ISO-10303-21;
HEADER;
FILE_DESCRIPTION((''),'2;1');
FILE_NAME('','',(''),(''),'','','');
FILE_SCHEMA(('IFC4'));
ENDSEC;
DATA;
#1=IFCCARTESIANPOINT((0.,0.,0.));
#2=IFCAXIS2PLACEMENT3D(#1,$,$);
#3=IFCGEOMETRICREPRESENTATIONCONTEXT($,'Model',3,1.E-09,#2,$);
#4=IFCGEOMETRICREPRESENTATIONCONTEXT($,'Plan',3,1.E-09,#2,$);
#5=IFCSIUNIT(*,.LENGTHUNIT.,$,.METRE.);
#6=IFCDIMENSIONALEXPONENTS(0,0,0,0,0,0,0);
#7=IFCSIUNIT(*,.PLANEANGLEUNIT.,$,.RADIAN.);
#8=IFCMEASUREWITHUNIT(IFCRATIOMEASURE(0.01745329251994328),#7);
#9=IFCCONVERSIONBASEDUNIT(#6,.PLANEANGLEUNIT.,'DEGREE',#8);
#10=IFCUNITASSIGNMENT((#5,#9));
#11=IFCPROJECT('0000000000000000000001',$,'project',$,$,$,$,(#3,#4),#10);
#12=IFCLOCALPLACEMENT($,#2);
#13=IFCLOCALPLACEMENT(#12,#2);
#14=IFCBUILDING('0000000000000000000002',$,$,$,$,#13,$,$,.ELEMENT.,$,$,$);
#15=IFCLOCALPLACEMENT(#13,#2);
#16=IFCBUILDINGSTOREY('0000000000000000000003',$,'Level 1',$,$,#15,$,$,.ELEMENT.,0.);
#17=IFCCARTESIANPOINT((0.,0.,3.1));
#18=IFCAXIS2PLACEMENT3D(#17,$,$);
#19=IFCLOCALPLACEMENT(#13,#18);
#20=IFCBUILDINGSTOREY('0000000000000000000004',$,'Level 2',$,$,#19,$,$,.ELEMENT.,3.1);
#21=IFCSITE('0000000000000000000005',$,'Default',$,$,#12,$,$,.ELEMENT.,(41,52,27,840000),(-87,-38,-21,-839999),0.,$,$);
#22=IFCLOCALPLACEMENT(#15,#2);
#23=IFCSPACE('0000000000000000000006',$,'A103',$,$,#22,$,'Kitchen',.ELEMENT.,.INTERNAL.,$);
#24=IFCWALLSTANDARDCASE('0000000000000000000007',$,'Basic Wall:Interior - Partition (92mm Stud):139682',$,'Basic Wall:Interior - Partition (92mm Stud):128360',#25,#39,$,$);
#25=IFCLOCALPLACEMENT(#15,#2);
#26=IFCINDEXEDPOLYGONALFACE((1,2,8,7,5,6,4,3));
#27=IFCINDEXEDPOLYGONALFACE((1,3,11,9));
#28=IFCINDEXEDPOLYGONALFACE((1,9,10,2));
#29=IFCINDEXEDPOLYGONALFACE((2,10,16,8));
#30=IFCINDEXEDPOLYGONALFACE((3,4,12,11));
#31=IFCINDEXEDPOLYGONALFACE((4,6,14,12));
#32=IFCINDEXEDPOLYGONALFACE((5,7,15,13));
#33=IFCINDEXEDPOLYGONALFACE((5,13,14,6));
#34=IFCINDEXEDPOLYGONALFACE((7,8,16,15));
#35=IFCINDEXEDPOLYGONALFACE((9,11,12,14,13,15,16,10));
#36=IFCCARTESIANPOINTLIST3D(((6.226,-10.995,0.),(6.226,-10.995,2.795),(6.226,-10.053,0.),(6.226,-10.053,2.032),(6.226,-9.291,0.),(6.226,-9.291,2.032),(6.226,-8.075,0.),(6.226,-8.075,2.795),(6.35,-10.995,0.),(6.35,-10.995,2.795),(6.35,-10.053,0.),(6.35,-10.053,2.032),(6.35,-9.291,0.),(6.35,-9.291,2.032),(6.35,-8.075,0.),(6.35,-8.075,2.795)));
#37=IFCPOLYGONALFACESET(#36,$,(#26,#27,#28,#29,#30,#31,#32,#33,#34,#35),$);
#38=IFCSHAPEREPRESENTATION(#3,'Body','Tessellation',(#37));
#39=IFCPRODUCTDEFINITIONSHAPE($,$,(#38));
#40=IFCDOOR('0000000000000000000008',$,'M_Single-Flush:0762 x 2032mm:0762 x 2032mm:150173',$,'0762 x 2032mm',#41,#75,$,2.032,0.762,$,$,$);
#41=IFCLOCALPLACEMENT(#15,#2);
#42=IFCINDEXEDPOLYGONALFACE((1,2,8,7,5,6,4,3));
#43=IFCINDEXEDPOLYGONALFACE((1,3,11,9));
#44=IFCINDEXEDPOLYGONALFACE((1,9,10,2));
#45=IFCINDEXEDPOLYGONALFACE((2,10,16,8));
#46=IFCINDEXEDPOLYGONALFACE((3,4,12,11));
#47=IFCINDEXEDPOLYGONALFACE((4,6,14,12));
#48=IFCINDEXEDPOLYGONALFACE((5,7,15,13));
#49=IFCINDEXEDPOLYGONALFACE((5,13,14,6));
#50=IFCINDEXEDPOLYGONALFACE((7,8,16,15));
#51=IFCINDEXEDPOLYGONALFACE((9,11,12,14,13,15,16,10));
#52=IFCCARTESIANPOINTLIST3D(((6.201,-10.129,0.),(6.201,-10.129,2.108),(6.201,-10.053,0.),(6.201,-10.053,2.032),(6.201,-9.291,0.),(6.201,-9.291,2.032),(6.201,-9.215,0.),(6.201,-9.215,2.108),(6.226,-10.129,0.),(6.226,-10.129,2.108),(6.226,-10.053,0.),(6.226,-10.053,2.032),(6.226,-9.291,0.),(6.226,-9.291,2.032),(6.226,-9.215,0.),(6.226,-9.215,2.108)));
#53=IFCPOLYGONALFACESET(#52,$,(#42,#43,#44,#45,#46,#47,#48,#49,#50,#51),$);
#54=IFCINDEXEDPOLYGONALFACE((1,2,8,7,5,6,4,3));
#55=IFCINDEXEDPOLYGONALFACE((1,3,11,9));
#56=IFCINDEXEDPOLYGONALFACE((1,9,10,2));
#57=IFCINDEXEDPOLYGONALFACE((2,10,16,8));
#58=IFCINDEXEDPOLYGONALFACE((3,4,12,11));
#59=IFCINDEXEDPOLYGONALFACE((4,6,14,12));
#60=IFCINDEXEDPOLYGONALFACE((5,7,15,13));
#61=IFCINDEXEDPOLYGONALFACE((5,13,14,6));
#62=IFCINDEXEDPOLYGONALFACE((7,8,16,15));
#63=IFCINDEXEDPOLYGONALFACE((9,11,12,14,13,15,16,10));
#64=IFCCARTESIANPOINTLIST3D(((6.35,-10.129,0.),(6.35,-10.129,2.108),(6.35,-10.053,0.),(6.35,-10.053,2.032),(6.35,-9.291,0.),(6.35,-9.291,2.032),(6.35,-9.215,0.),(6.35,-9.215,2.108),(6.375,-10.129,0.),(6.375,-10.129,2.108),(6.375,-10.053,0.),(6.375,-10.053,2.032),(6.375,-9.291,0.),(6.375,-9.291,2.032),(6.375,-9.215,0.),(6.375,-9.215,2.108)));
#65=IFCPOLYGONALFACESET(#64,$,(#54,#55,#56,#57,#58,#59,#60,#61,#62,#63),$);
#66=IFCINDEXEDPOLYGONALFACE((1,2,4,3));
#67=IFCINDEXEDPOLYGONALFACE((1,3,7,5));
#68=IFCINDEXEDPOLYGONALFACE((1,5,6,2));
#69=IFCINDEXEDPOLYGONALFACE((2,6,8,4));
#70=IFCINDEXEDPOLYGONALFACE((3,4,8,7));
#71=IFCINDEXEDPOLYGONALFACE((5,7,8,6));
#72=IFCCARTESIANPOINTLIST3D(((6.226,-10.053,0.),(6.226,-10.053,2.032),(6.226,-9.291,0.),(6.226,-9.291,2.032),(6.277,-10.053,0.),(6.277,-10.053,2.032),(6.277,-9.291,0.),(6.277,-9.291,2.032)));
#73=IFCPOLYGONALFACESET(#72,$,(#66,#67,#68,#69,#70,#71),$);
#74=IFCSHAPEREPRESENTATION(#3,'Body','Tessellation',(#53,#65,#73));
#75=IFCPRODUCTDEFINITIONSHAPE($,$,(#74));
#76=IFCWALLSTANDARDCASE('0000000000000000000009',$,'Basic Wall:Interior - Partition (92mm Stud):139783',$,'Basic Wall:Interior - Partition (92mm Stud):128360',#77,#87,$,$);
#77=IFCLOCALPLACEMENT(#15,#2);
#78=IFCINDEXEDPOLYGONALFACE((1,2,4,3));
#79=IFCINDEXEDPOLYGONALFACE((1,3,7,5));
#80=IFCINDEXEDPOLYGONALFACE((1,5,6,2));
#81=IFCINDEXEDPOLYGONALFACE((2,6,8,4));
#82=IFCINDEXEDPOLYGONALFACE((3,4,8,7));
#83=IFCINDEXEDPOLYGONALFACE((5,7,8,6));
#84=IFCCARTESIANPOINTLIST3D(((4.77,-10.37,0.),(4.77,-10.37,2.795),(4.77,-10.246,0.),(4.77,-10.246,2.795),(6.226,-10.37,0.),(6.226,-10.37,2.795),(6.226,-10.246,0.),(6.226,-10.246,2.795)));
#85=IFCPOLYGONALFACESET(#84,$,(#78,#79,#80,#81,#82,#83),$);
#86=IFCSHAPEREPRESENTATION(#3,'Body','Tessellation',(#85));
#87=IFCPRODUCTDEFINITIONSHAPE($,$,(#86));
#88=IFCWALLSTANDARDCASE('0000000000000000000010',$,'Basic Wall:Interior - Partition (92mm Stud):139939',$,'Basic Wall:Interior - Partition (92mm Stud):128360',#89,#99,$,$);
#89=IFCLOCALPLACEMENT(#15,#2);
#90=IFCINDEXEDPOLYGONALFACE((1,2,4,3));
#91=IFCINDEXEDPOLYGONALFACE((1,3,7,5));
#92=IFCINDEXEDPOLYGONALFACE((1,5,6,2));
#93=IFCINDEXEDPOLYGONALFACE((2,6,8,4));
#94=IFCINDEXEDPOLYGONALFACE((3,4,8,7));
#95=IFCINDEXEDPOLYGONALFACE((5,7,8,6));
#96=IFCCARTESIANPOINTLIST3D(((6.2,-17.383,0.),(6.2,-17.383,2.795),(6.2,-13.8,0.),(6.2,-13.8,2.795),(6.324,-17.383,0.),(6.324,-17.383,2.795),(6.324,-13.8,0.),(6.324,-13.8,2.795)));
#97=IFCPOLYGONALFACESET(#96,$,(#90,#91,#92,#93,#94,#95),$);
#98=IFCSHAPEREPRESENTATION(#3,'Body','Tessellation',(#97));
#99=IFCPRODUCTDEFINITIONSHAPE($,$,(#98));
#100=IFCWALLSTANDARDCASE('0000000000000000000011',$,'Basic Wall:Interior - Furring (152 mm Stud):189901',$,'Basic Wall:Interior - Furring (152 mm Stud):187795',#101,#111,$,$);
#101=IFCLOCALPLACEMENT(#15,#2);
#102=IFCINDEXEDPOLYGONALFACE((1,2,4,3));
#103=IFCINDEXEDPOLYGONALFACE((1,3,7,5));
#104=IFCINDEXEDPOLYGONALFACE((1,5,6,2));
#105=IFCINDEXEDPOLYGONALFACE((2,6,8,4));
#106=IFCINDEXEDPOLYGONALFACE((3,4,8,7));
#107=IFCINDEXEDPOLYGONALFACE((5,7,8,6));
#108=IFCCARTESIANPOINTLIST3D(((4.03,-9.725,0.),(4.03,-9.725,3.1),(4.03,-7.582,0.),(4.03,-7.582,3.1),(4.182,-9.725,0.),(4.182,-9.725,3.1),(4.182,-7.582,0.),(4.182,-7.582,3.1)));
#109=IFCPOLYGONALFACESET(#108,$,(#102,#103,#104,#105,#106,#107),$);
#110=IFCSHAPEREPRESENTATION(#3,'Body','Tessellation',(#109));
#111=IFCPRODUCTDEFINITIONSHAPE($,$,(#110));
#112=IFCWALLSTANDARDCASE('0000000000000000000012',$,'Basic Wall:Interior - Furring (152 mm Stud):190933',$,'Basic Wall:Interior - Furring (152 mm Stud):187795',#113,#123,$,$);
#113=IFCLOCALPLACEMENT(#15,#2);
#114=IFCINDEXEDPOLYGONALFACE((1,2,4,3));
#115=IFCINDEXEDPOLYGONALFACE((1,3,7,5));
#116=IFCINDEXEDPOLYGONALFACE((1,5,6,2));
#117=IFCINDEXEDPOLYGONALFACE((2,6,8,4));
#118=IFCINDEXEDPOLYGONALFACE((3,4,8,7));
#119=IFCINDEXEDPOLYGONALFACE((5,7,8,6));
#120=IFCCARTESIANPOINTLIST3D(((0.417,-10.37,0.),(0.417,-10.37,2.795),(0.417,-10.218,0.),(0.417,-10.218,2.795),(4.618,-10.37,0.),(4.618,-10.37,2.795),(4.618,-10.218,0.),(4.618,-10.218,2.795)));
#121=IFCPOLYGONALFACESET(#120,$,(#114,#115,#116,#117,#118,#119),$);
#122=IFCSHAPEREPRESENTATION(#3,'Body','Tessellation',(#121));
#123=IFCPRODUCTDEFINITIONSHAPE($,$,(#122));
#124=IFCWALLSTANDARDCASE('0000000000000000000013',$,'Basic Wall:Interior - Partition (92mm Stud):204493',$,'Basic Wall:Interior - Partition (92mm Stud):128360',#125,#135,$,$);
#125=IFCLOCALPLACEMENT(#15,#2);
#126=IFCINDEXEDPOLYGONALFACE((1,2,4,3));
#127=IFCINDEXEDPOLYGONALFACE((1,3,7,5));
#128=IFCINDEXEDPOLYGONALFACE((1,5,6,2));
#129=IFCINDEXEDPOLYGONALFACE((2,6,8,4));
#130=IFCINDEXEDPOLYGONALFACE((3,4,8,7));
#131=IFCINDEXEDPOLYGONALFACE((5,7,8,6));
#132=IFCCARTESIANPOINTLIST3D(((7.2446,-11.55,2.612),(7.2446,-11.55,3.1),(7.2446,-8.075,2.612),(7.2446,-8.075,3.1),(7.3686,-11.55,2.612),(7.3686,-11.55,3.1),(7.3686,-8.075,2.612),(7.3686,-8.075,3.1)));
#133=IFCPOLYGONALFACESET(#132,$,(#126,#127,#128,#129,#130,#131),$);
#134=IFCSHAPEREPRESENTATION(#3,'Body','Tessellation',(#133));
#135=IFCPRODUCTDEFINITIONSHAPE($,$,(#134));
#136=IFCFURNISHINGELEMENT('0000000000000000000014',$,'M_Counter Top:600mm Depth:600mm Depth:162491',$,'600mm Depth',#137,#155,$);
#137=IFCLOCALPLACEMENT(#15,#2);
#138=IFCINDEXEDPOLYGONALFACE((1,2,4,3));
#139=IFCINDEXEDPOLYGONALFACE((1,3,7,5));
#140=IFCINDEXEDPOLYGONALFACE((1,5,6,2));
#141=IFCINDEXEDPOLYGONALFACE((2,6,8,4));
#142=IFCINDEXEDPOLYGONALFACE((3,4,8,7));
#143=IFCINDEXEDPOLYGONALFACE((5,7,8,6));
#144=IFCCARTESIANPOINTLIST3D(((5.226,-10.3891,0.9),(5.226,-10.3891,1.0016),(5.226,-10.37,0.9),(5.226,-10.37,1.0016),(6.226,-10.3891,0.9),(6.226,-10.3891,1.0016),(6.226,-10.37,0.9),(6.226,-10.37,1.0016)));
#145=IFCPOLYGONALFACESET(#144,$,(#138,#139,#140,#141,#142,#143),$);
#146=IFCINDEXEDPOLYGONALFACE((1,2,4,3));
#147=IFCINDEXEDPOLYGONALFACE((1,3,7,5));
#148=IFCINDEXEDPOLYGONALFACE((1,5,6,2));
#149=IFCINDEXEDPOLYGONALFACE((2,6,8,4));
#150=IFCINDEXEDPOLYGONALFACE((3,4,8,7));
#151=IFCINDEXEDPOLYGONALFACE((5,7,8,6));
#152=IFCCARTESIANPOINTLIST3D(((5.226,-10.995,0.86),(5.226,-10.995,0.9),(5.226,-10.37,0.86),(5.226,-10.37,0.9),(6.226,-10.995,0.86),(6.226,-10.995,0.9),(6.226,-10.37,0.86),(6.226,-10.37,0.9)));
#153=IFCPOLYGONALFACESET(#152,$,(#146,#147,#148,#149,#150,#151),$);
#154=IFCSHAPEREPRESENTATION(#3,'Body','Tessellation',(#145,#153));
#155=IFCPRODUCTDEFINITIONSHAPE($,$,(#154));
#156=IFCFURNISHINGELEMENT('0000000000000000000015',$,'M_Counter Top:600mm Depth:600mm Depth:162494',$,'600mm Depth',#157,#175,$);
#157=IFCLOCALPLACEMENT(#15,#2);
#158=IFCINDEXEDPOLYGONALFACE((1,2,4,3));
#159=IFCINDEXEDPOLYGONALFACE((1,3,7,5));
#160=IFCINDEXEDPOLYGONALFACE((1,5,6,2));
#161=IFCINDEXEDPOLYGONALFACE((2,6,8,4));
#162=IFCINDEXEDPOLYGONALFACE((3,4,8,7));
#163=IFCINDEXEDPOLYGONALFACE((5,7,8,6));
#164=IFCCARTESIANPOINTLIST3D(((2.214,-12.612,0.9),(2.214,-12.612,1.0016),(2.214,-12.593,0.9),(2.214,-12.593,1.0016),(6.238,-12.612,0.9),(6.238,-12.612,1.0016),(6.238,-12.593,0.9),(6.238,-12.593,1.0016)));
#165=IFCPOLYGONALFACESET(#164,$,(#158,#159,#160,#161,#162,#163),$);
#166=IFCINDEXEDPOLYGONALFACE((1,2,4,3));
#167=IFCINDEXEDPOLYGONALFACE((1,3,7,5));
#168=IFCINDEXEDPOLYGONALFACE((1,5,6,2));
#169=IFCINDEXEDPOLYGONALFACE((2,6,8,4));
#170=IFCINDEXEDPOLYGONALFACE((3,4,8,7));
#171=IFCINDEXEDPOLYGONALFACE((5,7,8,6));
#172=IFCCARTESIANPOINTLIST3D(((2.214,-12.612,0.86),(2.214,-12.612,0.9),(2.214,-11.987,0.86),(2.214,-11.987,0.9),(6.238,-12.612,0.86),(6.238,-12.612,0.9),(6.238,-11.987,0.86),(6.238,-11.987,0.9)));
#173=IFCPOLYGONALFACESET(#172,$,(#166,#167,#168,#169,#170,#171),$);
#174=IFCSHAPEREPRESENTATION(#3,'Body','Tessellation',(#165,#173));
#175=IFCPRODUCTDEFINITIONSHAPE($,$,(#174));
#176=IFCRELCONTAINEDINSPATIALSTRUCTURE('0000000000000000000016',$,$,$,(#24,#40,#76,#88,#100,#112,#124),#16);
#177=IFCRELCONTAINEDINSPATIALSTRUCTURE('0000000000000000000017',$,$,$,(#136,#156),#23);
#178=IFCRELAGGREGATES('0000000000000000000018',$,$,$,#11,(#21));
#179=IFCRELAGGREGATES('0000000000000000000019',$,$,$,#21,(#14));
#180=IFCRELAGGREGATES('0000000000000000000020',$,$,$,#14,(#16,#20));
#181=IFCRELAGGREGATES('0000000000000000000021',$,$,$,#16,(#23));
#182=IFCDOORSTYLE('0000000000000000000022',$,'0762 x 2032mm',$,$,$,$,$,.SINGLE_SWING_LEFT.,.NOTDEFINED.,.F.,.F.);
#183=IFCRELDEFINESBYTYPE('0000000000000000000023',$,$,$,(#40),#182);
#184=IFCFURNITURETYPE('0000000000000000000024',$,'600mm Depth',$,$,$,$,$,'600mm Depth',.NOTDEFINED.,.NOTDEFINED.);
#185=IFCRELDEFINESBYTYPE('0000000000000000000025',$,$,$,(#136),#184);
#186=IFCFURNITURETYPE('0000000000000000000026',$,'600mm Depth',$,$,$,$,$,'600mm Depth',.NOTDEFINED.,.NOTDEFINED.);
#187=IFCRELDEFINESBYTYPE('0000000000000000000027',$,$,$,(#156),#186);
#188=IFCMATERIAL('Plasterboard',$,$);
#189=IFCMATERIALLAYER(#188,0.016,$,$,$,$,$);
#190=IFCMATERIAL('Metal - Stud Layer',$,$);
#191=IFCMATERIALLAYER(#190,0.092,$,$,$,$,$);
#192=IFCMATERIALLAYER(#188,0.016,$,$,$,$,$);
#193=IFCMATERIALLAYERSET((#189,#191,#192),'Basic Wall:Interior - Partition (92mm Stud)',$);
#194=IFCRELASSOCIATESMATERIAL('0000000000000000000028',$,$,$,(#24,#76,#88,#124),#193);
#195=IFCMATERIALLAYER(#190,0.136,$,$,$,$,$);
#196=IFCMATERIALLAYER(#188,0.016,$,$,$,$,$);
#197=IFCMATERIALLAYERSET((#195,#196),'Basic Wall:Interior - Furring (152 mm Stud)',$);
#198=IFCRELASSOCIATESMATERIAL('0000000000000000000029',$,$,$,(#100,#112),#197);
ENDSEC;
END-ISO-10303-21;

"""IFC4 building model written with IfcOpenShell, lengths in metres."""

from ifc_helpers import new_model, entity, si_unit, converted_unit, frame, frame_2d, origin, origin_2d_with_axis, place, context, project, spatial, polyline, rectangle, outline, extrude, source, transform, mapped, material, layer, layer_set, layer_usage, type_object, type_shapes, element, fill, save


model = new_model("IFC4")

# Units and contexts
model_context = context("Model", 3, precision=1e-09, world=origin())
plan_context = context("Plan", 3, precision=1e-09, world=origin())
ifc_project = project(units=[si_unit("LENGTHUNIT", "METRE"), converted_unit("PLANEANGLEUNIT", "DEGREE", entity("IfcRatioMeasure", 0.01745329251994328), si_unit("PLANEANGLEUNIT", "RADIAN"), dimensions=[0, 0, 0, 0, 0, 0, 0])], contexts=[model_context, plan_context])

# Site, building, storey
site_placement = place(None, origin())
site = spatial("IfcSite", under=ifc_project, at=site_placement, Name="Default", CompositionType="ELEMENT", RefLatitude=(41, 52, 27, 840000), RefLongitude=(-87, -38, -21, -839999), RefElevation=0.0)
building_placement = place(site_placement, origin())
building = spatial("IfcBuilding", under=site, at=building_placement, CompositionType="ELEMENT")
storey_1_placement = place(building_placement, origin())
storey_1 = spatial("IfcBuildingStorey", under=building, at=storey_1_placement, Name="Level 1", CompositionType="ELEMENT", Elevation=0.0)

# Shared definitions
ifc_material_1 = material(Name="Metal - Stud Layer")
ifc_material_2 = material(Name="Plasterboard")

# Wall, opening, door
ifc_layer_1 = layer(ifc_material_2, 0.016)
ifc_layer_2 = layer(ifc_material_1, 0.092)
ifc_layer_3 = layer(ifc_material_2, 0.016)
ifc_layer_set_1 = layer_set([ifc_layer_1, ifc_layer_2, ifc_layer_3], Name="Basic Wall:Interior - Partition (92mm Stud)")
ifc_layer_usage_1 = layer_usage(ifc_layer_set_1, "AXIS2", "NEGATIVE", 0.062)
wall_1_placement = place(storey_1_placement, frame((6.288, -10.995, 0.0), z_axis=(0.0, 0.0, 1.0), x_axis=(0.0, 1.0, 0.0)))
wall_1 = element("IfcWallStandardCase", 1, at=wall_1_placement, inside=storey_1, material=ifc_layer_usage_1, Name="Basic Wall:Interior - Partition (92mm Stud):139682", ObjectType="Basic Wall:Interior - Partition (92mm Stud):128360", context=model_context, shape_type="SweptSolid", body=[
    extrude(rectangle(XDim=2.92, YDim=0.124, at=frame_2d((1.46, 0.0), x_axis=(-1.0, 0.0))), origin(), (0.0, 0.0, 1.0), 2.795),
])
opening_1_placement = place(wall_1_placement, frame((0.942, -0.062, 0.0)))
opening_1 = element("IfcOpeningElement", 2, at=opening_1_placement, cuts=wall_1, ObjectType="Opening", context=model_context, shape_type="SweptSolid", body=[
    extrude(rectangle(XDim=0.762, YDim=2.032, at=frame_2d((1.016, 0.381), x_axis=(0.0, -1.0))), frame((0.0, 0.0, 0.0), z_axis=(0.0, 1.0, 0.0), x_axis=(0.0, 0.0, 1.0)), (0.0, 0.0, 1.0), 0.124),
])
door_style_1 = type_object("IfcDoorStyle", Name="0762 x 2032mm", ConstructionType="NOTDEFINED", OperationType="SINGLE_SWING_LEFT", ParameterTakesPrecedence=False, Sizeable=False)
shared_shape_1 = source(origin(), model_context, "Body", "SweptSolid", [
    extrude(outline(polyline([(-0.457, -1.073), (0.457, -1.073), (0.457, 1.035), (0.381, 1.035), (0.381, -0.997), (-0.381, -0.997), (-0.381, 1.035), (-0.457, 1.035), (-0.457, -1.073)])), frame((0.381, 0.149, 1.035), z_axis=(0.0, -1.0, 0.0), x_axis=(-1.0, 0.0, 0.0)), (0.0, 0.0, 1.0), 0.025),
    extrude(outline(polyline([(-1.073, -0.457), (1.035, -0.457), (1.035, -0.381), (-0.997, -0.381), (-0.997, 0.381), (1.035, 0.381), (1.035, 0.457), (-1.073, 0.457), (-1.073, -0.457)])), frame((0.381, 0.0, 1.035), z_axis=(0.0, -1.0, 0.0), x_axis=(0.0, 0.0, -1.0)), (0.0, 0.0, 1.0), 0.025),
    extrude(rectangle(XDim=0.762, YDim=0.051, at=origin_2d_with_axis()), frame((0.381, 0.0985, 0.0)), (0.0, 0.0, 1.0), 2.032),
])
type_shapes(door_style_1, [shared_shape_1])
door_1_placement = place(opening_1_placement, origin())
door_1 = element("IfcDoor", 3, at=door_1_placement, inside=storey_1, type_object=door_style_1, Name="M_Single-Flush:0762 x 2032mm:0762 x 2032mm:150173", ObjectType="0762 x 2032mm", OverallHeight=2.032, OverallWidth=0.762, context=model_context, shape_type="MappedRepresentation", body=[
    mapped(shared_shape_1, transform((0.0, 0.0, 0.0), scale=1.0)),
])
fill(opening_1, door_1)

# Walls
ifc_layer_usage_2 = layer_usage(ifc_layer_set_1, "AXIS2", "NEGATIVE", 0.062)
wall_2_placement = place(storey_1_placement, frame((4.77, -10.308, 0.0)))
element("IfcWallStandardCase", 4, at=wall_2_placement, inside=storey_1, material=ifc_layer_usage_2, Name="Basic Wall:Interior - Partition (92mm Stud):139783", ObjectType="Basic Wall:Interior - Partition (92mm Stud):128360", context=model_context, shape_type="SweptSolid", body=[
    extrude(rectangle(XDim=1.456, YDim=0.124, at=frame_2d((0.728, 0.0), x_axis=(-1.0, 0.0))), origin(), (0.0, 0.0, 1.0), 2.795),
])
ifc_layer_usage_3 = layer_usage(ifc_layer_set_1, "AXIS2", "NEGATIVE", 0.062)
wall_3_placement = place(storey_1_placement, frame((6.262, -13.8, 0.0), z_axis=(0.0, 0.0, 1.0), x_axis=(0.0, -1.0, 0.0)))
element("IfcWallStandardCase", 5, at=wall_3_placement, inside=storey_1, material=ifc_layer_usage_3, Name="Basic Wall:Interior - Partition (92mm Stud):139939", ObjectType="Basic Wall:Interior - Partition (92mm Stud):128360", context=model_context, shape_type="SweptSolid", body=[
    extrude(rectangle(XDim=3.583, YDim=0.124, at=frame_2d((1.7915, 0.0), x_axis=(-1.0, 0.0))), origin(), (0.0, 0.0, 1.0), 2.795),
])

# Shared definitions
storey_2_placement = place(building_placement, frame((0.0, 0.0, 3.1)))
storey_2 = spatial("IfcBuildingStorey", under=building, at=storey_2_placement, Name="Level 2", CompositionType="ELEMENT", Elevation=3.1)

# Walls
ifc_layer_4 = layer(ifc_material_1, 0.136)
ifc_layer_5 = layer(ifc_material_2, 0.016)
ifc_layer_set_2 = layer_set([ifc_layer_4, ifc_layer_5], Name="Basic Wall:Interior - Furring (152 mm Stud)")
ifc_layer_usage_4 = layer_usage(ifc_layer_set_2, "AXIS2", "POSITIVE", -0.076)
wall_4_placement = place(storey_1_placement, frame((4.106, -9.725, 0.0), z_axis=(0.0, 0.0, 1.0), x_axis=(0.0, 1.0, 0.0)))
element("IfcWallStandardCase", 6, at=wall_4_placement, inside=storey_1, material=ifc_layer_usage_4, Name="Basic Wall:Interior - Furring (152 mm Stud):189901", ObjectType="Basic Wall:Interior - Furring (152 mm Stud):187795", context=model_context, shape_type="SweptSolid", body=[
    extrude(rectangle(XDim=2.143, YDim=0.152, at=frame_2d((1.0715, 0.0), x_axis=(-1.0, 0.0))), origin(), (0.0, 0.0, 1.0), 3.1),
])
ifc_layer_usage_5 = layer_usage(ifc_layer_set_2, "AXIS2", "NEGATIVE", 0.076)
wall_5_placement = place(storey_1_placement, frame((0.417, -10.294, 0.0)))
element("IfcWallStandardCase", 7, at=wall_5_placement, inside=storey_1, material=ifc_layer_usage_5, Name="Basic Wall:Interior - Furring (152 mm Stud):190933", ObjectType="Basic Wall:Interior - Furring (152 mm Stud):187795", context=model_context, shape_type="SweptSolid", body=[
    extrude(rectangle(XDim=4.201, YDim=0.152, at=frame_2d((2.1005, 0.0), x_axis=(-1.0, 0.0))), origin(), (0.0, 0.0, 1.0), 2.795),
])
ifc_layer_usage_6 = layer_usage(ifc_layer_set_1, "AXIS2", "NEGATIVE", 0.062)
wall_6_placement = place(storey_1_placement, frame((7.3066, -11.55, 2.612), z_axis=(0.0, 0.0, 1.0), x_axis=(0.0, 1.0, 0.0)))
element("IfcWallStandardCase", 8, at=wall_6_placement, inside=storey_1, material=ifc_layer_usage_6, Name="Basic Wall:Interior - Partition (92mm Stud):204493", ObjectType="Basic Wall:Interior - Partition (92mm Stud):128360", context=model_context, shape_type="SweptSolid", body=[
    extrude(rectangle(XDim=3.475, YDim=0.124, at=frame_2d((1.7375, 0.0), x_axis=(-1.0, 0.0))), origin(), (0.0, 0.0, 1.0), 0.488),
])

# Shared definitions
space_1_placement = place(storey_1_placement, origin())
space_1 = spatial("IfcSpace", under=storey_1, at=space_1_placement, Name="A103", LongName="Kitchen", CompositionType="ELEMENT", PredefinedType="INTERNAL")

# Furnishing elements
furniture_type_1 = type_object("IfcFurnitureType", Name="600mm Depth", ElementType="600mm Depth", AssemblyPlace="NOTDEFINED")
shared_shape_2 = source(origin(), model_context, "Body", "SweptSolid", [
    extrude(rectangle(XDim=0.0191, YDim=1.0, at=origin_2d_with_axis()), frame((-0.7005, -0.0095, 0.9), z_axis=(0.0, 0.0, 1.0), x_axis=(0.0, -1.0, 0.0)), (0.0, 0.0, 1.0), 0.1016),
    extrude(rectangle(XDim=1.0, YDim=0.625, at=origin_2d_with_axis()), frame((-0.7005, -0.3125, 0.86), z_axis=(0.0, 0.0, 1.0), x_axis=(-1.0, 0.0, 0.0)), (0.0, 0.0, 1.0), 0.04),
])
type_shapes(furniture_type_1, [shared_shape_2])
furnishing_1_placement = place(space_1_placement, frame((6.4265, -10.37, 0.0)))
element("IfcFurnishingElement", 9, at=furnishing_1_placement, inside=space_1, type_object=furniture_type_1, Name="M_Counter Top:600mm Depth:600mm Depth:162491", ObjectType="600mm Depth", context=model_context, shape_type="MappedRepresentation", body=[
    mapped(shared_shape_2, transform((0.0, 0.0, 0.0), scale=1.0)),
])
furniture_type_2 = type_object("IfcFurnitureType", Name="600mm Depth", ElementType="600mm Depth", AssemblyPlace="NOTDEFINED")
shared_shape_3 = source(origin(), model_context, "Body", "SweptSolid", [
    extrude(rectangle(XDim=0.0191, YDim=4.024, at=origin_2d_with_axis()), frame((0.8115, -0.0095, 0.9), z_axis=(0.0, 0.0, 1.0), x_axis=(0.0, -1.0, 0.0)), (0.0, 0.0, 1.0), 0.1016),
    extrude(rectangle(XDim=4.024, YDim=0.625, at=origin_2d_with_axis()), frame((0.8115, -0.3125, 0.86), z_axis=(0.0, 0.0, 1.0), x_axis=(-1.0, 0.0, 0.0)), (0.0, 0.0, 1.0), 0.04),
])
type_shapes(furniture_type_2, [shared_shape_3])
furnishing_2_placement = place(space_1_placement, frame((5.0375, -12.612, 0.0), z_axis=(0.0, 0.0, 1.0), x_axis=(-1.0, 0.0, 0.0)))
element("IfcFurnishingElement", 10, at=furnishing_2_placement, inside=space_1, type_object=furniture_type_2, Name="M_Counter Top:600mm Depth:600mm Depth:162494", ObjectType="600mm Depth", context=model_context, shape_type="MappedRepresentation", body=[
    mapped(shared_shape_3, transform((0.0, 0.0, 0.0), scale=1.0)),
])

save(model, "model.ifc")
